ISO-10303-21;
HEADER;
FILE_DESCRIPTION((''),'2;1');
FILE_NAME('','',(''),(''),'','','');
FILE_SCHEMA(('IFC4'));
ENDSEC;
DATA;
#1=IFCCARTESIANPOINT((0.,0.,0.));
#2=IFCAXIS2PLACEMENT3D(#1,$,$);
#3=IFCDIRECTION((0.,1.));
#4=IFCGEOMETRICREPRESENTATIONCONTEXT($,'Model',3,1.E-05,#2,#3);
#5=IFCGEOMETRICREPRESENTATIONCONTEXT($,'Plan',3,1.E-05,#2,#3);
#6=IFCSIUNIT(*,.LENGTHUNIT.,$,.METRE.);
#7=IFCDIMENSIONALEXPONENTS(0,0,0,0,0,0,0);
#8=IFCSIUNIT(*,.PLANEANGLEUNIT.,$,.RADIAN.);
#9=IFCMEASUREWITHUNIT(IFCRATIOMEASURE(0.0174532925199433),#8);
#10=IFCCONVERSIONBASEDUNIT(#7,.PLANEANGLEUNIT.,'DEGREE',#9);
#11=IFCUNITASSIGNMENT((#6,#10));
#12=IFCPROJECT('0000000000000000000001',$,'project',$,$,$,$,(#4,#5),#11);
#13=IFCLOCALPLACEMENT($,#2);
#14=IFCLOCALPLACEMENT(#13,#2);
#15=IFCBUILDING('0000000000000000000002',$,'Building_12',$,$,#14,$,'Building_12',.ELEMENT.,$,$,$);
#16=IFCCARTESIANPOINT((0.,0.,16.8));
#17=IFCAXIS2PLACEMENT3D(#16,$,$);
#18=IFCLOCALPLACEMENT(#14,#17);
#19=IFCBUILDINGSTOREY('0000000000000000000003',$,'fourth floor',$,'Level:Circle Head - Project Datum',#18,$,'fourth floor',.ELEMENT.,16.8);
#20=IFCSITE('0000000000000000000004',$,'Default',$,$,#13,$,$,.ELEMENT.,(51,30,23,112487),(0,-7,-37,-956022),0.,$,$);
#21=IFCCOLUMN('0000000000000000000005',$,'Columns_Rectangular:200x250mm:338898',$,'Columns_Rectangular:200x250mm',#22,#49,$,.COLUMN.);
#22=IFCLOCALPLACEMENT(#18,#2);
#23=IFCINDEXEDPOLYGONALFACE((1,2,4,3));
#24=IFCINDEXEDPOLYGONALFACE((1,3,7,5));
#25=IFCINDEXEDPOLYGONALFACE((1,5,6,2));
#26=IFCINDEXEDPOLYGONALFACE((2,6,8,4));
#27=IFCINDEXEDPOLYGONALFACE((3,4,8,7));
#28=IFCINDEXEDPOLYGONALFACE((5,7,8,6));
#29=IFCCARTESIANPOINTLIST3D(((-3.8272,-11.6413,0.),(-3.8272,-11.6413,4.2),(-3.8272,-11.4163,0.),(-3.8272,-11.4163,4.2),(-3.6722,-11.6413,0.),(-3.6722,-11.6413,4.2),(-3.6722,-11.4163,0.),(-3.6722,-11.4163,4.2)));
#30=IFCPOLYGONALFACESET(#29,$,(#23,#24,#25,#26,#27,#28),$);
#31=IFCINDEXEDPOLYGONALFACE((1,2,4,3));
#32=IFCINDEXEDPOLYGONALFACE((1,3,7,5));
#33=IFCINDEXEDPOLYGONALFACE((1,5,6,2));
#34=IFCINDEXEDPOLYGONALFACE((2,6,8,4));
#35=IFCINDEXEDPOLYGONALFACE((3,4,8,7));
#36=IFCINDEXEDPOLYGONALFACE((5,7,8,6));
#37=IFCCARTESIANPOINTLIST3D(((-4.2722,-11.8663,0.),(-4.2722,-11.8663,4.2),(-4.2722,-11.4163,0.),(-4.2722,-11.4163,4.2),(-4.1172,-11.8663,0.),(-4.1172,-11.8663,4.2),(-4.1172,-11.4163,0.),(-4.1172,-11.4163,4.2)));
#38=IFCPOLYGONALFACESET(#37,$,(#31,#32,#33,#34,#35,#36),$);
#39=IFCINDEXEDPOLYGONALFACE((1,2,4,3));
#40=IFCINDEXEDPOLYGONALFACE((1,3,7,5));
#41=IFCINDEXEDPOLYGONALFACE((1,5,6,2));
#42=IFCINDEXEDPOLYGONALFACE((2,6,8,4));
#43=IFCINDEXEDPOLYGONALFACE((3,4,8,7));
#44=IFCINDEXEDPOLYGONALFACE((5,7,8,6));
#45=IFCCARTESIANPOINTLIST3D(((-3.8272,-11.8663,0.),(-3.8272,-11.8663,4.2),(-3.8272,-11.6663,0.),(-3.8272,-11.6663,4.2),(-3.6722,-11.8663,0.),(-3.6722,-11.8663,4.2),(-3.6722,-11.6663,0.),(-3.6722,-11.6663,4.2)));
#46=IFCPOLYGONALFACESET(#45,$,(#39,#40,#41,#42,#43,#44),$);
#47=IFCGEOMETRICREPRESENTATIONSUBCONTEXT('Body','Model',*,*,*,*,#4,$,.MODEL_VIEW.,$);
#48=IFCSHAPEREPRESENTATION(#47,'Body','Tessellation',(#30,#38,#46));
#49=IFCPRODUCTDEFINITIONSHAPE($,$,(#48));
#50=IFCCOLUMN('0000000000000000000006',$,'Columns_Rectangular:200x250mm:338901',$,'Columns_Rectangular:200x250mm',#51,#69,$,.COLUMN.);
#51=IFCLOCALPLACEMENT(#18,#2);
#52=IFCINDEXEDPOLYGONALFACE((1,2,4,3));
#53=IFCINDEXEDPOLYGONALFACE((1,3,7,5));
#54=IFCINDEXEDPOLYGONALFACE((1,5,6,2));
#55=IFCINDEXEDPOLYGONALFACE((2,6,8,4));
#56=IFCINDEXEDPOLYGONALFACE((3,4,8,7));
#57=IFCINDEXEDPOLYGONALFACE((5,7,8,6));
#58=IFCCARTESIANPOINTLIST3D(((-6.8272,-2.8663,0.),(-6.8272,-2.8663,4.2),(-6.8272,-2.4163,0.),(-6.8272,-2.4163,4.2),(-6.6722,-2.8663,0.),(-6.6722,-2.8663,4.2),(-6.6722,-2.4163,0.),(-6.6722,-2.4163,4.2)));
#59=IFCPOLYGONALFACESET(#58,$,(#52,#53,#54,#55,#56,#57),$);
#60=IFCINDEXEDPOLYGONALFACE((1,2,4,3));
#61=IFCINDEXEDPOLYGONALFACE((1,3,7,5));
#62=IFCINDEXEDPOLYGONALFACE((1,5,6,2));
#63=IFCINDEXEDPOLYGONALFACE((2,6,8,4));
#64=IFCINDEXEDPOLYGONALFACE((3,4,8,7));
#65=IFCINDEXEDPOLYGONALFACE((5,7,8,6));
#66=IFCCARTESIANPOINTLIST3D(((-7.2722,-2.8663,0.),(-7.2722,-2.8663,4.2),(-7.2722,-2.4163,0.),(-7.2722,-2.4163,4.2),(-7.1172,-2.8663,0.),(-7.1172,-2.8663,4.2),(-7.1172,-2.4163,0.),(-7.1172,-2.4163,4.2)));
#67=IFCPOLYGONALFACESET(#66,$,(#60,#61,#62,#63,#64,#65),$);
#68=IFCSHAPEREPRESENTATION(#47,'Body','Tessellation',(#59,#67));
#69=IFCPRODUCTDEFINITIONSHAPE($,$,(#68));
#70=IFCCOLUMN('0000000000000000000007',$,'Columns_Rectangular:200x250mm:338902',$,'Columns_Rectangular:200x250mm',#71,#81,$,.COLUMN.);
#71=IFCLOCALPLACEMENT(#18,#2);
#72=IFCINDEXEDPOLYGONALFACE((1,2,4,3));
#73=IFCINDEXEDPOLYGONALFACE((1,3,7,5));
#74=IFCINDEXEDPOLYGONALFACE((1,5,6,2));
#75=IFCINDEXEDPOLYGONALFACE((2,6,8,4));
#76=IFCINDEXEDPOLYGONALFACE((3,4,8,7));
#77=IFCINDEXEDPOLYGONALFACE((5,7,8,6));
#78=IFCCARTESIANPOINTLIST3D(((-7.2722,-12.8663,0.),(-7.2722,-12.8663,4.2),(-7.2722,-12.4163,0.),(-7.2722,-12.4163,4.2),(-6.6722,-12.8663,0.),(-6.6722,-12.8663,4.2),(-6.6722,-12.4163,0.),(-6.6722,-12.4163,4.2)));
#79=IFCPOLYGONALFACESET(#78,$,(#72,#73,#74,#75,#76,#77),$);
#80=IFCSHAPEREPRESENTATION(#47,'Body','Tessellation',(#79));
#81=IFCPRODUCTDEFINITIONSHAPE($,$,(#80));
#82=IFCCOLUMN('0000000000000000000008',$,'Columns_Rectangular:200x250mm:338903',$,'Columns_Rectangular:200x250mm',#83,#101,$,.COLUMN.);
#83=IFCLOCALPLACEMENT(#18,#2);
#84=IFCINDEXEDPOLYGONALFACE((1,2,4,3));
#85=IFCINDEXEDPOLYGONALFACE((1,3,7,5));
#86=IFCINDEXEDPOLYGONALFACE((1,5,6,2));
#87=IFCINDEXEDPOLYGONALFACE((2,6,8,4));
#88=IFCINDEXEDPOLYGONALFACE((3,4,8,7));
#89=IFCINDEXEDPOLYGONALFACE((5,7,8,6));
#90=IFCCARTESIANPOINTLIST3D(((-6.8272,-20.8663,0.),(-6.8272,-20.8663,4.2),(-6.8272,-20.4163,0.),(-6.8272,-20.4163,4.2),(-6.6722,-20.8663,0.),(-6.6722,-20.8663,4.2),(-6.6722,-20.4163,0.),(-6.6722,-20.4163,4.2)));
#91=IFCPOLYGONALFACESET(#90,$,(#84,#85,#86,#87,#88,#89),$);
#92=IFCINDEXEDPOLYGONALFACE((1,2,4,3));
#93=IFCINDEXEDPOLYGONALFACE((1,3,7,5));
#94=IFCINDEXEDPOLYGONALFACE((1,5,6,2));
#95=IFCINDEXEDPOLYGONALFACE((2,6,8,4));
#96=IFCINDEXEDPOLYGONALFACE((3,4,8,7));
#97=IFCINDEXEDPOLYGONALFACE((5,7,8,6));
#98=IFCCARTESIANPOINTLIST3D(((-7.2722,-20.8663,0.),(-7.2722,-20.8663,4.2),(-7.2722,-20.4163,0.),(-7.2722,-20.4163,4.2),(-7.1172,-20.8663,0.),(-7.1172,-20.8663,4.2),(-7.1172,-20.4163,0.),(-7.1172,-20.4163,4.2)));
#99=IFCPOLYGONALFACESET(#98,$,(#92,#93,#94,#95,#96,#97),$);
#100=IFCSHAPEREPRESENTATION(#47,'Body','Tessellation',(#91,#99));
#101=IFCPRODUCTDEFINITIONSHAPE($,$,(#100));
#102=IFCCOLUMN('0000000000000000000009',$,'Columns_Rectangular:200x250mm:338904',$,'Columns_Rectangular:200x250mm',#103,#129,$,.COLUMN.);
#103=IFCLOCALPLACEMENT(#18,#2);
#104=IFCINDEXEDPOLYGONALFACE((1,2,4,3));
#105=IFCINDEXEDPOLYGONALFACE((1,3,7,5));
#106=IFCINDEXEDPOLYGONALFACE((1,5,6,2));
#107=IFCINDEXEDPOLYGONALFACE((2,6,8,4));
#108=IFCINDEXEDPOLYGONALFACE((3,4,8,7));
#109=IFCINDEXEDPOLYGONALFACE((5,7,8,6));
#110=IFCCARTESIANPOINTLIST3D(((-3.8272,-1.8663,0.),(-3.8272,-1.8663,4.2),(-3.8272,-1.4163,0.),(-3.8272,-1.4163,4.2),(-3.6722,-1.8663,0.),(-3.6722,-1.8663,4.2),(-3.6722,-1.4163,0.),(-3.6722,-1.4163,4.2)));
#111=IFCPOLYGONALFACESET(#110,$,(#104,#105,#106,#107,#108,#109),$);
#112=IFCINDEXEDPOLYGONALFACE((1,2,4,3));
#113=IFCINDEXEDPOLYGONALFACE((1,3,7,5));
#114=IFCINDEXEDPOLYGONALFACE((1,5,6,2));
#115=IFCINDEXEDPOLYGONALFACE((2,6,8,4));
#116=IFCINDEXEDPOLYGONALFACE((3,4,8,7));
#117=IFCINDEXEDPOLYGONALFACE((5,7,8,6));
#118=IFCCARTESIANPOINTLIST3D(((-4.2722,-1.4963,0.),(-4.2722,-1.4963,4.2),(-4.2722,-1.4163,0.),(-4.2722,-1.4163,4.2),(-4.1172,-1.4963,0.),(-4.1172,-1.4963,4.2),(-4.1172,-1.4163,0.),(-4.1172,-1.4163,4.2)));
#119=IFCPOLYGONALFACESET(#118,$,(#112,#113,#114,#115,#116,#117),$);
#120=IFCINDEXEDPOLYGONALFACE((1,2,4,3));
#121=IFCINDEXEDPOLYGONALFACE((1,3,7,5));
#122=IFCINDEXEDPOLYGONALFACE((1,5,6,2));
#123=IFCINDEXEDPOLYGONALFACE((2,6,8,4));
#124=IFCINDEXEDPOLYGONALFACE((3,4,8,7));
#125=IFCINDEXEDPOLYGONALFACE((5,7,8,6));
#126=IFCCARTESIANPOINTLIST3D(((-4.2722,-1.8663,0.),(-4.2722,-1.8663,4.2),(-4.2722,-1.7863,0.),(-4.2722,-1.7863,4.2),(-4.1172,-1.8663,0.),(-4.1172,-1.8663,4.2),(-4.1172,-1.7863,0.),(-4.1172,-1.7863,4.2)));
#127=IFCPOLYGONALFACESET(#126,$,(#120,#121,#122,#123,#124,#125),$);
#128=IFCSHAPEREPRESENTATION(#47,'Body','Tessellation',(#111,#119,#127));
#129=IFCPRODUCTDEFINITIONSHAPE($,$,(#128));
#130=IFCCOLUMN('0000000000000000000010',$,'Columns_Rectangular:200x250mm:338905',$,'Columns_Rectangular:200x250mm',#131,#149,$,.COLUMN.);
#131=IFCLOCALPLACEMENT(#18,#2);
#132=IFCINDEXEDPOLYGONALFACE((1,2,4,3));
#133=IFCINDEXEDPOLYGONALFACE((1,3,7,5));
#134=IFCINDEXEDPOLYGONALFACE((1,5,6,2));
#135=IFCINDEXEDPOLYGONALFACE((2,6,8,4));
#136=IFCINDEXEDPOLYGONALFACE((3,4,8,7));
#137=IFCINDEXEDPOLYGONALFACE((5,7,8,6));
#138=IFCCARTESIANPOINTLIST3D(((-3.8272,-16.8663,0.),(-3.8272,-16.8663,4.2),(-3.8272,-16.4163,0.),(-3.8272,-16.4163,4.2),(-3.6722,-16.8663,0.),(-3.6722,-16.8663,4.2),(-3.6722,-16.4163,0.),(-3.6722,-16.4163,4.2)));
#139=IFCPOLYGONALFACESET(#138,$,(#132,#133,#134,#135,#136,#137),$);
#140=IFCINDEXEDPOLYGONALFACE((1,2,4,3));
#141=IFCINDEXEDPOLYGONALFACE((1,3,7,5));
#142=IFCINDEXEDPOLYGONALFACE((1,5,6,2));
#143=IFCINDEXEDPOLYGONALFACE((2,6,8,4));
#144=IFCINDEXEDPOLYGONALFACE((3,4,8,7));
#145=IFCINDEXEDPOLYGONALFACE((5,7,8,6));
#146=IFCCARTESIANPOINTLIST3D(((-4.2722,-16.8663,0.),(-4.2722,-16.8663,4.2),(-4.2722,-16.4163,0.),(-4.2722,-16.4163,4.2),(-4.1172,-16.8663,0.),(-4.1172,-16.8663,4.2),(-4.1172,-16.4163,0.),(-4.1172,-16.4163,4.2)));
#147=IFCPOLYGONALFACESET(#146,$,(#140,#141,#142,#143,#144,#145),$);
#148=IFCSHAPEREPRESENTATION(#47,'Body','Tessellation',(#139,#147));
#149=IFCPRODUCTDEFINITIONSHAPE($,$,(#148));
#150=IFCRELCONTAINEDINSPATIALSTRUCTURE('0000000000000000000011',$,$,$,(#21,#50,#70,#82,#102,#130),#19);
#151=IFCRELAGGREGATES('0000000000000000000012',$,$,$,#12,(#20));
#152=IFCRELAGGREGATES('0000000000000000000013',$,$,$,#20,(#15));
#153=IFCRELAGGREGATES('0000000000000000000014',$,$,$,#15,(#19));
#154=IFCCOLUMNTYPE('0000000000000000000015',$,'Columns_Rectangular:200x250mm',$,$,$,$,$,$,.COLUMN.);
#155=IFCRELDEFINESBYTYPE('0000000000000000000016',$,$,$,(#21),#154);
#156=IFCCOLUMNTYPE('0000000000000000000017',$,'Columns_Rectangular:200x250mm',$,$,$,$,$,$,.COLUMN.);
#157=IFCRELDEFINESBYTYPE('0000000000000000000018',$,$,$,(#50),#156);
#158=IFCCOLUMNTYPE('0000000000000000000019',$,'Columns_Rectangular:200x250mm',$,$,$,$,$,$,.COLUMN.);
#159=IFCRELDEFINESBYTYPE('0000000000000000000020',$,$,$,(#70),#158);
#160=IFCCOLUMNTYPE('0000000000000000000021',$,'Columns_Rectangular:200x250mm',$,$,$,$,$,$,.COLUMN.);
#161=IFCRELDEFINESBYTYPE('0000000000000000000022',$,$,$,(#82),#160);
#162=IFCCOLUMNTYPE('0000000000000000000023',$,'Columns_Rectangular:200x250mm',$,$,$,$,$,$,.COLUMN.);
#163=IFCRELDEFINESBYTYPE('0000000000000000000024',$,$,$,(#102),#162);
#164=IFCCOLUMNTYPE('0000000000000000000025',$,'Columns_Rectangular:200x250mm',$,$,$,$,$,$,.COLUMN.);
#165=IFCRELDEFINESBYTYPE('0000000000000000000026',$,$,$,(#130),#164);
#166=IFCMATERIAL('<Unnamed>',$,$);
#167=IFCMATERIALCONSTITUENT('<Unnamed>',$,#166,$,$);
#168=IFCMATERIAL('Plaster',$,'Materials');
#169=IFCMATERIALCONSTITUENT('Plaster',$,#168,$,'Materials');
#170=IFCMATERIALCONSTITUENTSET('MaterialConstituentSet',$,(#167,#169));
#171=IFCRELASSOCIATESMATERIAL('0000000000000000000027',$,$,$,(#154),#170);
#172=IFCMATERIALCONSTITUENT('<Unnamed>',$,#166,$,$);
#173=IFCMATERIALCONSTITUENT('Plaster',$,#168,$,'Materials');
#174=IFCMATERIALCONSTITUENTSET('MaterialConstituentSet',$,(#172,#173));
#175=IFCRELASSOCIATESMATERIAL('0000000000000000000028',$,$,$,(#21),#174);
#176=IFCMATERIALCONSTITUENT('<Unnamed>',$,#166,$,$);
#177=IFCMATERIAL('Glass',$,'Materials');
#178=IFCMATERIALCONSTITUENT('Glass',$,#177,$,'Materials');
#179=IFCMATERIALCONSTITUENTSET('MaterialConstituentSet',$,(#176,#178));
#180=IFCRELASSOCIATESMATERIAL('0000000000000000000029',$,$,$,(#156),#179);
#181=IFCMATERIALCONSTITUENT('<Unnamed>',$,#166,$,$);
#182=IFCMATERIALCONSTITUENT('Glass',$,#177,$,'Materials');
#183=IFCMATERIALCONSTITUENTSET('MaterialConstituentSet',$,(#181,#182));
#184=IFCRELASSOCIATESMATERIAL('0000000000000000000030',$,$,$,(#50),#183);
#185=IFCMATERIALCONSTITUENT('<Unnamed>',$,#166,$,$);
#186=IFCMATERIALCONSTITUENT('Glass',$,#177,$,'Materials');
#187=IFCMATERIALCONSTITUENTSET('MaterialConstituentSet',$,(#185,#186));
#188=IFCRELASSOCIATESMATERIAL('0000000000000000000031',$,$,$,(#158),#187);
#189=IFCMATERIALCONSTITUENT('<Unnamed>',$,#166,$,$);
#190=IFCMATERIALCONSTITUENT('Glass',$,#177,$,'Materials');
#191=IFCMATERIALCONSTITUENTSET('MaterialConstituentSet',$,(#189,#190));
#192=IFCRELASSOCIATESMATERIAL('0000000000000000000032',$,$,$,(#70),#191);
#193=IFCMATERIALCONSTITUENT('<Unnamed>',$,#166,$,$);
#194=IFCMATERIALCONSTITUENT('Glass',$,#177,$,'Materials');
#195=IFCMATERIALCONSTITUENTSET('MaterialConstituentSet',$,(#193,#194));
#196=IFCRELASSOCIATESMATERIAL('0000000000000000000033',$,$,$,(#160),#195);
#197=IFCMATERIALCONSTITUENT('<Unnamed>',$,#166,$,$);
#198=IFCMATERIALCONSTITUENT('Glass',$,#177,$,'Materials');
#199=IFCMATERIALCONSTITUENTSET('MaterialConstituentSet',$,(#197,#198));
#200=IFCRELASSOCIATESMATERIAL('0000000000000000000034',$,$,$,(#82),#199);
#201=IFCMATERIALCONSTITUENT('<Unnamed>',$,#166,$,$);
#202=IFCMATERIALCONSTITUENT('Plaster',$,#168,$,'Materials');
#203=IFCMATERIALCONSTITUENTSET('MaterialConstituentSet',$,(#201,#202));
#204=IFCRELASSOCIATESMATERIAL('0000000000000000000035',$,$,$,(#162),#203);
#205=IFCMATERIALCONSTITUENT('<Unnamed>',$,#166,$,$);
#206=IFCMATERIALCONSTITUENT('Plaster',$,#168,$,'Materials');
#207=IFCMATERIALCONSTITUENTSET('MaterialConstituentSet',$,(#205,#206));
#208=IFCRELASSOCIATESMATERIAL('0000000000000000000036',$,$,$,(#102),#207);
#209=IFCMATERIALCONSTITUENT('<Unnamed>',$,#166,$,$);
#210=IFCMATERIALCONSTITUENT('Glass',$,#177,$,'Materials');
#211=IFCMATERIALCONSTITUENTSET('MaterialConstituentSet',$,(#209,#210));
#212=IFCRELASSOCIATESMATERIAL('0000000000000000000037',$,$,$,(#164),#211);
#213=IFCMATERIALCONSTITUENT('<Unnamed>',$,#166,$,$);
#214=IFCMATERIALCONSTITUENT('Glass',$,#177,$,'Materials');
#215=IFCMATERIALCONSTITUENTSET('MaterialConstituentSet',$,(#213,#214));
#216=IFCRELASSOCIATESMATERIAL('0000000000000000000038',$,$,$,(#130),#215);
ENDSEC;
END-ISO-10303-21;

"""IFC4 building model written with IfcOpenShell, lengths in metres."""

from ifc_helpers import new_model, entity, si_unit, converted_unit, direction, frame, origin, place, context, subcontext, project, spatial, indexed_curve, outline, extrude, source, transform, mapped, material, constituent, constituent_set, type_object, type_shapes, element, save


model = new_model("IFC4")

# Units and contexts
model_context = context("Model", 3, precision=1e-05, world=origin(), true_north=direction((0.0, 1.0)))
plan_context = context("Plan", 3, precision=1e-05, world=origin(), true_north=direction((0.0, 1.0)))
body_context = subcontext(model_context, "Body", "Model", "MODEL_VIEW")
ifc_project = project(units=[si_unit("LENGTHUNIT", "METRE"), converted_unit("PLANEANGLEUNIT", "DEGREE", entity("IfcRatioMeasure", 0.0174532925199433), si_unit("PLANEANGLEUNIT", "RADIAN"), dimensions=[0, 0, 0, 0, 0, 0, 0])], contexts=[model_context, plan_context])

# Site, building, storey
site_placement = place(None, origin())
site = spatial("IfcSite", under=ifc_project, at=site_placement, Name="Default", CompositionType="ELEMENT", RefLatitude=(51, 30, 23, 112487), RefLongitude=(0, -7, -37, -956022), RefElevation=0.0)
building_placement = place(site_placement, origin())
building = spatial("IfcBuilding", under=site, at=building_placement, Name="Building_12", LongName="Building_12", CompositionType="ELEMENT")
storey_placement = place(building_placement, frame((0.0, 0.0, 16.8)))
storey = spatial("IfcBuildingStorey", under=building, at=storey_placement, Name="fourth floor", ObjectType="Level:Circle Head - Project Datum", LongName="fourth floor", CompositionType="ELEMENT", Elevation=16.8)

# Columns
ifc_material_1 = material(Name="<Unnamed>")
ifc_material_2 = material(Name="Plaster", Category="Materials")
ifc_constituent_1 = constituent(ifc_material_1, Name="<Unnamed>")
ifc_constituent_2 = constituent(ifc_material_2, Name="Plaster", Category="Materials")
ifc_constituent_set_1 = constituent_set(constituents=[ifc_constituent_1, ifc_constituent_2], Name="MaterialConstituentSet")
ifc_constituent_3 = constituent(ifc_material_1, Name="<Unnamed>")
ifc_constituent_4 = constituent(ifc_material_2, Name="Plaster", Category="Materials")
ifc_constituent_set_2 = constituent_set(constituents=[ifc_constituent_3, ifc_constituent_4], Name="MaterialConstituentSet")
column_type_1 = type_object("IfcColumnType", Name="Columns_Rectangular:200x250mm", PredefinedType="COLUMN", material=ifc_constituent_set_2)
shared_shape_1 = source(origin(), body_context, "Body", "SweptSolid", [
    extrude(outline(indexed_curve([(-0.1125, -0.0775), (0.1125, -0.0775), (0.1125, 0.0775), (-0.1125, 0.0775), (-0.1125, -0.0775)], self_intersect=False)), frame((-3.7497, -11.5288, 16.8), z_axis=(0.0, 0.0, 1.0), x_axis=(0.0, -1.0, 0.0)), (0.0, 0.0, 1.0), 4.2),
    extrude(outline(indexed_curve([(-0.225, -0.0775), (0.225, -0.0775), (0.225, 0.0775), (-0.225, 0.0775), (-0.225, -0.0775)], self_intersect=False)), frame((-4.1947, -11.6413, 16.8), z_axis=(0.0, 0.0, 1.0), x_axis=(0.0, -1.0, 0.0)), (0.0, 0.0, 1.0), 4.2),
    extrude(outline(indexed_curve([(-0.1, -0.0775), (0.1, -0.0775), (0.1, 0.0775), (-0.1, 0.0775), (-0.1, -0.0775)], self_intersect=False)), frame((-3.7497, -11.7663, 16.8), z_axis=(0.0, 0.0, 1.0), x_axis=(0.0, -1.0, 0.0)), (0.0, 0.0, 1.0), 4.2),
])
type_shapes(column_type_1, [shared_shape_1])
column_1_placement = place(storey_placement, frame((0.0, 0.0, -16.8)))
element("IfcColumn", 1, at=column_1_placement, inside=storey, type_object=column_type_1, material=ifc_constituent_set_1, Name="Columns_Rectangular:200x250mm:338898", ObjectType="Columns_Rectangular:200x250mm", PredefinedType="COLUMN", context=body_context, shape_type="MappedRepresentation", body=[
    mapped(shared_shape_1, transform((0.0, 0.0, 0.0), scale=1.0)),
])
ifc_constituent_5 = constituent(ifc_material_1, Name="<Unnamed>")
ifc_material_3 = material(Name="Glass", Category="Materials")
ifc_constituent_6 = constituent(ifc_material_3, Name="Glass", Category="Materials")
ifc_constituent_set_3 = constituent_set(constituents=[ifc_constituent_5, ifc_constituent_6], Name="MaterialConstituentSet")
ifc_constituent_7 = constituent(ifc_material_1, Name="<Unnamed>")
ifc_constituent_8 = constituent(ifc_material_3, Name="Glass", Category="Materials")
ifc_constituent_set_4 = constituent_set(constituents=[ifc_constituent_7, ifc_constituent_8], Name="MaterialConstituentSet")
column_type_2 = type_object("IfcColumnType", Name="Columns_Rectangular:200x250mm", PredefinedType="COLUMN", material=ifc_constituent_set_4)
shared_shape_2 = source(origin(), body_context, "Body", "SweptSolid", [
    extrude(outline(indexed_curve([(-0.225, -0.0775), (0.225, -0.0775), (0.225, 0.0775), (-0.225, 0.0775), (-0.225, -0.0775)], self_intersect=False)), frame((-6.7497, -2.6413, 16.8), z_axis=(0.0, 0.0, 1.0), x_axis=(0.0, -1.0, 0.0)), (0.0, 0.0, 1.0), 4.2),
    extrude(outline(indexed_curve([(-0.225, -0.0775), (0.225, -0.0775), (0.225, 0.0775), (-0.225, 0.0775), (-0.225, -0.0775)], self_intersect=False)), frame((-7.1947, -2.6413, 16.8), z_axis=(0.0, 0.0, 1.0), x_axis=(0.0, -1.0, 0.0)), (0.0, 0.0, 1.0), 4.2),
])
type_shapes(column_type_2, [shared_shape_2])
column_2_placement = place(storey_placement, frame((0.0, 0.0, -16.8)))
element("IfcColumn", 2, at=column_2_placement, inside=storey, type_object=column_type_2, material=ifc_constituent_set_3, Name="Columns_Rectangular:200x250mm:338901", ObjectType="Columns_Rectangular:200x250mm", PredefinedType="COLUMN", context=body_context, shape_type="MappedRepresentation", body=[
    mapped(shared_shape_2, transform((0.0, 0.0, 0.0), scale=1.0)),
])
ifc_constituent_9 = constituent(ifc_material_1, Name="<Unnamed>")
ifc_constituent_10 = constituent(ifc_material_3, Name="Glass", Category="Materials")
ifc_constituent_set_5 = constituent_set(constituents=[ifc_constituent_9, ifc_constituent_10], Name="MaterialConstituentSet")
ifc_constituent_11 = constituent(ifc_material_1, Name="<Unnamed>")
ifc_constituent_12 = constituent(ifc_material_3, Name="Glass", Category="Materials")
ifc_constituent_set_6 = constituent_set(constituents=[ifc_constituent_11, ifc_constituent_12], Name="MaterialConstituentSet")
column_type_3 = type_object("IfcColumnType", Name="Columns_Rectangular:200x250mm", PredefinedType="COLUMN", material=ifc_constituent_set_6)
shared_shape_3 = source(origin(), body_context, "Body", "SweptSolid", [
    extrude(outline(indexed_curve([(-0.225, -0.3), (0.225, -0.3), (0.225, 0.3), (-0.225, 0.3), (-0.225, -0.3)], self_intersect=False)), frame((-6.9722, -12.6413, 16.8), z_axis=(0.0, 0.0, 1.0), x_axis=(0.0, -1.0, 0.0)), (0.0, 0.0, 1.0), 4.2),
])
type_shapes(column_type_3, [shared_shape_3])
column_3_placement = place(storey_placement, frame((0.0, 0.0, -16.8)))
element("IfcColumn", 3, at=column_3_placement, inside=storey, type_object=column_type_3, material=ifc_constituent_set_5, Name="Columns_Rectangular:200x250mm:338902", ObjectType="Columns_Rectangular:200x250mm", PredefinedType="COLUMN", context=body_context, shape_type="MappedRepresentation", body=[
    mapped(shared_shape_3, transform((0.0, 0.0, 0.0), scale=1.0)),
])
ifc_constituent_13 = constituent(ifc_material_1, Name="<Unnamed>")
ifc_constituent_14 = constituent(ifc_material_3, Name="Glass", Category="Materials")
ifc_constituent_set_7 = constituent_set(constituents=[ifc_constituent_13, ifc_constituent_14], Name="MaterialConstituentSet")
ifc_constituent_15 = constituent(ifc_material_1, Name="<Unnamed>")
ifc_constituent_16 = constituent(ifc_material_3, Name="Glass", Category="Materials")
ifc_constituent_set_8 = constituent_set(constituents=[ifc_constituent_15, ifc_constituent_16], Name="MaterialConstituentSet")
column_type_4 = type_object("IfcColumnType", Name="Columns_Rectangular:200x250mm", PredefinedType="COLUMN", material=ifc_constituent_set_8)
shared_shape_4 = source(origin(), body_context, "Body", "SweptSolid", [
    extrude(outline(indexed_curve([(-0.225, -0.0775), (0.225, -0.0775), (0.225, 0.0775), (-0.225, 0.0775), (-0.225, -0.0775)], self_intersect=False)), frame((-6.7497, -20.6413, 16.8), z_axis=(0.0, 0.0, 1.0), x_axis=(0.0, -1.0, 0.0)), (0.0, 0.0, 1.0), 4.2),
    extrude(outline(indexed_curve([(-0.225, -0.0775), (0.225, -0.0775), (0.225, 0.0775), (-0.225, 0.0775), (-0.225, -0.0775)], self_intersect=False)), frame((-7.1947, -20.6413, 16.8), z_axis=(0.0, 0.0, 1.0), x_axis=(0.0, -1.0, 0.0)), (0.0, 0.0, 1.0), 4.2),
])
type_shapes(column_type_4, [shared_shape_4])
column_4_placement = place(storey_placement, frame((0.0, 0.0, -16.8)))
element("IfcColumn", 4, at=column_4_placement, inside=storey, type_object=column_type_4, material=ifc_constituent_set_7, Name="Columns_Rectangular:200x250mm:338903", ObjectType="Columns_Rectangular:200x250mm", PredefinedType="COLUMN", context=body_context, shape_type="MappedRepresentation", body=[
    mapped(shared_shape_4, transform((0.0, 0.0, 0.0), scale=1.0)),
])
ifc_constituent_17 = constituent(ifc_material_1, Name="<Unnamed>")
ifc_constituent_18 = constituent(ifc_material_2, Name="Plaster", Category="Materials")
ifc_constituent_set_9 = constituent_set(constituents=[ifc_constituent_17, ifc_constituent_18], Name="MaterialConstituentSet")
ifc_constituent_19 = constituent(ifc_material_1, Name="<Unnamed>")
ifc_constituent_20 = constituent(ifc_material_2, Name="Plaster", Category="Materials")
ifc_constituent_set_10 = constituent_set(constituents=[ifc_constituent_19, ifc_constituent_20], Name="MaterialConstituentSet")
column_type_5 = type_object("IfcColumnType", Name="Columns_Rectangular:200x250mm", PredefinedType="COLUMN", material=ifc_constituent_set_10)
shared_shape_5 = source(origin(), body_context, "Body", "SweptSolid", [
    extrude(outline(indexed_curve([(-0.225, -0.0775), (0.225, -0.0775), (0.225, 0.0775), (-0.225, 0.0775), (-0.225, -0.0775)], self_intersect=False)), frame((-3.7497, -1.6413, 16.8), z_axis=(0.0, 0.0, 1.0), x_axis=(0.0, -1.0, 0.0)), (0.0, 0.0, 1.0), 4.2),
    extrude(outline(indexed_curve([(-0.04, -0.0775), (0.04, -0.0775), (0.04, 0.0775), (-0.04, 0.0775), (-0.04, -0.0775)], self_intersect=False)), frame((-4.1947, -1.4563, 16.8), z_axis=(0.0, 0.0, 1.0), x_axis=(0.0, -1.0, 0.0)), (0.0, 0.0, 1.0), 4.2),
    extrude(outline(indexed_curve([(-0.04, -0.0775), (0.04, -0.0775), (0.04, 0.0775), (-0.04, 0.0775), (-0.04, -0.0775)], self_intersect=False)), frame((-4.1947, -1.8263, 16.8), z_axis=(0.0, 0.0, 1.0), x_axis=(0.0, -1.0, 0.0)), (0.0, 0.0, 1.0), 4.2),
])
type_shapes(column_type_5, [shared_shape_5])
column_5_placement = place(storey_placement, frame((0.0, 0.0, -16.8)))
element("IfcColumn", 5, at=column_5_placement, inside=storey, type_object=column_type_5, material=ifc_constituent_set_9, Name="Columns_Rectangular:200x250mm:338904", ObjectType="Columns_Rectangular:200x250mm", PredefinedType="COLUMN", context=body_context, shape_type="MappedRepresentation", body=[
    mapped(shared_shape_5, transform((0.0, 0.0, 0.0), scale=1.0)),
])
ifc_constituent_21 = constituent(ifc_material_1, Name="<Unnamed>")
ifc_constituent_22 = constituent(ifc_material_3, Name="Glass", Category="Materials")
ifc_constituent_set_11 = constituent_set(constituents=[ifc_constituent_21, ifc_constituent_22], Name="MaterialConstituentSet")
ifc_constituent_23 = constituent(ifc_material_1, Name="<Unnamed>")
ifc_constituent_24 = constituent(ifc_material_3, Name="Glass", Category="Materials")
ifc_constituent_set_12 = constituent_set(constituents=[ifc_constituent_23, ifc_constituent_24], Name="MaterialConstituentSet")
column_type_6 = type_object("IfcColumnType", Name="Columns_Rectangular:200x250mm", PredefinedType="COLUMN", material=ifc_constituent_set_12)
shared_shape_6 = source(origin(), body_context, "Body", "SweptSolid", [
    extrude(outline(indexed_curve([(-0.225, -0.0775), (0.225, -0.0775), (0.225, 0.0775), (-0.225, 0.0775), (-0.225, -0.0775)], self_intersect=False)), frame((-3.7497, -16.6413, 16.8), z_axis=(0.0, 0.0, 1.0), x_axis=(0.0, -1.0, 0.0)), (0.0, 0.0, 1.0), 4.2),
    extrude(outline(indexed_curve([(-0.225, -0.0775), (0.225, -0.0775), (0.225, 0.0775), (-0.225, 0.0775), (-0.225, -0.0775)], self_intersect=False)), frame((-4.1947, -16.6413, 16.8), z_axis=(0.0, 0.0, 1.0), x_axis=(0.0, -1.0, 0.0)), (0.0, 0.0, 1.0), 4.2),
])
type_shapes(column_type_6, [shared_shape_6])
column_6_placement = place(storey_placement, frame((0.0, 0.0, -16.8)))
element("IfcColumn", 6, at=column_6_placement, inside=storey, type_object=column_type_6, material=ifc_constituent_set_11, Name="Columns_Rectangular:200x250mm:338905", ObjectType="Columns_Rectangular:200x250mm", PredefinedType="COLUMN", context=body_context, shape_type="MappedRepresentation", body=[
    mapped(shared_shape_6, transform((0.0, 0.0, 0.0), scale=1.0)),
])

save(model, "model.ifc")
